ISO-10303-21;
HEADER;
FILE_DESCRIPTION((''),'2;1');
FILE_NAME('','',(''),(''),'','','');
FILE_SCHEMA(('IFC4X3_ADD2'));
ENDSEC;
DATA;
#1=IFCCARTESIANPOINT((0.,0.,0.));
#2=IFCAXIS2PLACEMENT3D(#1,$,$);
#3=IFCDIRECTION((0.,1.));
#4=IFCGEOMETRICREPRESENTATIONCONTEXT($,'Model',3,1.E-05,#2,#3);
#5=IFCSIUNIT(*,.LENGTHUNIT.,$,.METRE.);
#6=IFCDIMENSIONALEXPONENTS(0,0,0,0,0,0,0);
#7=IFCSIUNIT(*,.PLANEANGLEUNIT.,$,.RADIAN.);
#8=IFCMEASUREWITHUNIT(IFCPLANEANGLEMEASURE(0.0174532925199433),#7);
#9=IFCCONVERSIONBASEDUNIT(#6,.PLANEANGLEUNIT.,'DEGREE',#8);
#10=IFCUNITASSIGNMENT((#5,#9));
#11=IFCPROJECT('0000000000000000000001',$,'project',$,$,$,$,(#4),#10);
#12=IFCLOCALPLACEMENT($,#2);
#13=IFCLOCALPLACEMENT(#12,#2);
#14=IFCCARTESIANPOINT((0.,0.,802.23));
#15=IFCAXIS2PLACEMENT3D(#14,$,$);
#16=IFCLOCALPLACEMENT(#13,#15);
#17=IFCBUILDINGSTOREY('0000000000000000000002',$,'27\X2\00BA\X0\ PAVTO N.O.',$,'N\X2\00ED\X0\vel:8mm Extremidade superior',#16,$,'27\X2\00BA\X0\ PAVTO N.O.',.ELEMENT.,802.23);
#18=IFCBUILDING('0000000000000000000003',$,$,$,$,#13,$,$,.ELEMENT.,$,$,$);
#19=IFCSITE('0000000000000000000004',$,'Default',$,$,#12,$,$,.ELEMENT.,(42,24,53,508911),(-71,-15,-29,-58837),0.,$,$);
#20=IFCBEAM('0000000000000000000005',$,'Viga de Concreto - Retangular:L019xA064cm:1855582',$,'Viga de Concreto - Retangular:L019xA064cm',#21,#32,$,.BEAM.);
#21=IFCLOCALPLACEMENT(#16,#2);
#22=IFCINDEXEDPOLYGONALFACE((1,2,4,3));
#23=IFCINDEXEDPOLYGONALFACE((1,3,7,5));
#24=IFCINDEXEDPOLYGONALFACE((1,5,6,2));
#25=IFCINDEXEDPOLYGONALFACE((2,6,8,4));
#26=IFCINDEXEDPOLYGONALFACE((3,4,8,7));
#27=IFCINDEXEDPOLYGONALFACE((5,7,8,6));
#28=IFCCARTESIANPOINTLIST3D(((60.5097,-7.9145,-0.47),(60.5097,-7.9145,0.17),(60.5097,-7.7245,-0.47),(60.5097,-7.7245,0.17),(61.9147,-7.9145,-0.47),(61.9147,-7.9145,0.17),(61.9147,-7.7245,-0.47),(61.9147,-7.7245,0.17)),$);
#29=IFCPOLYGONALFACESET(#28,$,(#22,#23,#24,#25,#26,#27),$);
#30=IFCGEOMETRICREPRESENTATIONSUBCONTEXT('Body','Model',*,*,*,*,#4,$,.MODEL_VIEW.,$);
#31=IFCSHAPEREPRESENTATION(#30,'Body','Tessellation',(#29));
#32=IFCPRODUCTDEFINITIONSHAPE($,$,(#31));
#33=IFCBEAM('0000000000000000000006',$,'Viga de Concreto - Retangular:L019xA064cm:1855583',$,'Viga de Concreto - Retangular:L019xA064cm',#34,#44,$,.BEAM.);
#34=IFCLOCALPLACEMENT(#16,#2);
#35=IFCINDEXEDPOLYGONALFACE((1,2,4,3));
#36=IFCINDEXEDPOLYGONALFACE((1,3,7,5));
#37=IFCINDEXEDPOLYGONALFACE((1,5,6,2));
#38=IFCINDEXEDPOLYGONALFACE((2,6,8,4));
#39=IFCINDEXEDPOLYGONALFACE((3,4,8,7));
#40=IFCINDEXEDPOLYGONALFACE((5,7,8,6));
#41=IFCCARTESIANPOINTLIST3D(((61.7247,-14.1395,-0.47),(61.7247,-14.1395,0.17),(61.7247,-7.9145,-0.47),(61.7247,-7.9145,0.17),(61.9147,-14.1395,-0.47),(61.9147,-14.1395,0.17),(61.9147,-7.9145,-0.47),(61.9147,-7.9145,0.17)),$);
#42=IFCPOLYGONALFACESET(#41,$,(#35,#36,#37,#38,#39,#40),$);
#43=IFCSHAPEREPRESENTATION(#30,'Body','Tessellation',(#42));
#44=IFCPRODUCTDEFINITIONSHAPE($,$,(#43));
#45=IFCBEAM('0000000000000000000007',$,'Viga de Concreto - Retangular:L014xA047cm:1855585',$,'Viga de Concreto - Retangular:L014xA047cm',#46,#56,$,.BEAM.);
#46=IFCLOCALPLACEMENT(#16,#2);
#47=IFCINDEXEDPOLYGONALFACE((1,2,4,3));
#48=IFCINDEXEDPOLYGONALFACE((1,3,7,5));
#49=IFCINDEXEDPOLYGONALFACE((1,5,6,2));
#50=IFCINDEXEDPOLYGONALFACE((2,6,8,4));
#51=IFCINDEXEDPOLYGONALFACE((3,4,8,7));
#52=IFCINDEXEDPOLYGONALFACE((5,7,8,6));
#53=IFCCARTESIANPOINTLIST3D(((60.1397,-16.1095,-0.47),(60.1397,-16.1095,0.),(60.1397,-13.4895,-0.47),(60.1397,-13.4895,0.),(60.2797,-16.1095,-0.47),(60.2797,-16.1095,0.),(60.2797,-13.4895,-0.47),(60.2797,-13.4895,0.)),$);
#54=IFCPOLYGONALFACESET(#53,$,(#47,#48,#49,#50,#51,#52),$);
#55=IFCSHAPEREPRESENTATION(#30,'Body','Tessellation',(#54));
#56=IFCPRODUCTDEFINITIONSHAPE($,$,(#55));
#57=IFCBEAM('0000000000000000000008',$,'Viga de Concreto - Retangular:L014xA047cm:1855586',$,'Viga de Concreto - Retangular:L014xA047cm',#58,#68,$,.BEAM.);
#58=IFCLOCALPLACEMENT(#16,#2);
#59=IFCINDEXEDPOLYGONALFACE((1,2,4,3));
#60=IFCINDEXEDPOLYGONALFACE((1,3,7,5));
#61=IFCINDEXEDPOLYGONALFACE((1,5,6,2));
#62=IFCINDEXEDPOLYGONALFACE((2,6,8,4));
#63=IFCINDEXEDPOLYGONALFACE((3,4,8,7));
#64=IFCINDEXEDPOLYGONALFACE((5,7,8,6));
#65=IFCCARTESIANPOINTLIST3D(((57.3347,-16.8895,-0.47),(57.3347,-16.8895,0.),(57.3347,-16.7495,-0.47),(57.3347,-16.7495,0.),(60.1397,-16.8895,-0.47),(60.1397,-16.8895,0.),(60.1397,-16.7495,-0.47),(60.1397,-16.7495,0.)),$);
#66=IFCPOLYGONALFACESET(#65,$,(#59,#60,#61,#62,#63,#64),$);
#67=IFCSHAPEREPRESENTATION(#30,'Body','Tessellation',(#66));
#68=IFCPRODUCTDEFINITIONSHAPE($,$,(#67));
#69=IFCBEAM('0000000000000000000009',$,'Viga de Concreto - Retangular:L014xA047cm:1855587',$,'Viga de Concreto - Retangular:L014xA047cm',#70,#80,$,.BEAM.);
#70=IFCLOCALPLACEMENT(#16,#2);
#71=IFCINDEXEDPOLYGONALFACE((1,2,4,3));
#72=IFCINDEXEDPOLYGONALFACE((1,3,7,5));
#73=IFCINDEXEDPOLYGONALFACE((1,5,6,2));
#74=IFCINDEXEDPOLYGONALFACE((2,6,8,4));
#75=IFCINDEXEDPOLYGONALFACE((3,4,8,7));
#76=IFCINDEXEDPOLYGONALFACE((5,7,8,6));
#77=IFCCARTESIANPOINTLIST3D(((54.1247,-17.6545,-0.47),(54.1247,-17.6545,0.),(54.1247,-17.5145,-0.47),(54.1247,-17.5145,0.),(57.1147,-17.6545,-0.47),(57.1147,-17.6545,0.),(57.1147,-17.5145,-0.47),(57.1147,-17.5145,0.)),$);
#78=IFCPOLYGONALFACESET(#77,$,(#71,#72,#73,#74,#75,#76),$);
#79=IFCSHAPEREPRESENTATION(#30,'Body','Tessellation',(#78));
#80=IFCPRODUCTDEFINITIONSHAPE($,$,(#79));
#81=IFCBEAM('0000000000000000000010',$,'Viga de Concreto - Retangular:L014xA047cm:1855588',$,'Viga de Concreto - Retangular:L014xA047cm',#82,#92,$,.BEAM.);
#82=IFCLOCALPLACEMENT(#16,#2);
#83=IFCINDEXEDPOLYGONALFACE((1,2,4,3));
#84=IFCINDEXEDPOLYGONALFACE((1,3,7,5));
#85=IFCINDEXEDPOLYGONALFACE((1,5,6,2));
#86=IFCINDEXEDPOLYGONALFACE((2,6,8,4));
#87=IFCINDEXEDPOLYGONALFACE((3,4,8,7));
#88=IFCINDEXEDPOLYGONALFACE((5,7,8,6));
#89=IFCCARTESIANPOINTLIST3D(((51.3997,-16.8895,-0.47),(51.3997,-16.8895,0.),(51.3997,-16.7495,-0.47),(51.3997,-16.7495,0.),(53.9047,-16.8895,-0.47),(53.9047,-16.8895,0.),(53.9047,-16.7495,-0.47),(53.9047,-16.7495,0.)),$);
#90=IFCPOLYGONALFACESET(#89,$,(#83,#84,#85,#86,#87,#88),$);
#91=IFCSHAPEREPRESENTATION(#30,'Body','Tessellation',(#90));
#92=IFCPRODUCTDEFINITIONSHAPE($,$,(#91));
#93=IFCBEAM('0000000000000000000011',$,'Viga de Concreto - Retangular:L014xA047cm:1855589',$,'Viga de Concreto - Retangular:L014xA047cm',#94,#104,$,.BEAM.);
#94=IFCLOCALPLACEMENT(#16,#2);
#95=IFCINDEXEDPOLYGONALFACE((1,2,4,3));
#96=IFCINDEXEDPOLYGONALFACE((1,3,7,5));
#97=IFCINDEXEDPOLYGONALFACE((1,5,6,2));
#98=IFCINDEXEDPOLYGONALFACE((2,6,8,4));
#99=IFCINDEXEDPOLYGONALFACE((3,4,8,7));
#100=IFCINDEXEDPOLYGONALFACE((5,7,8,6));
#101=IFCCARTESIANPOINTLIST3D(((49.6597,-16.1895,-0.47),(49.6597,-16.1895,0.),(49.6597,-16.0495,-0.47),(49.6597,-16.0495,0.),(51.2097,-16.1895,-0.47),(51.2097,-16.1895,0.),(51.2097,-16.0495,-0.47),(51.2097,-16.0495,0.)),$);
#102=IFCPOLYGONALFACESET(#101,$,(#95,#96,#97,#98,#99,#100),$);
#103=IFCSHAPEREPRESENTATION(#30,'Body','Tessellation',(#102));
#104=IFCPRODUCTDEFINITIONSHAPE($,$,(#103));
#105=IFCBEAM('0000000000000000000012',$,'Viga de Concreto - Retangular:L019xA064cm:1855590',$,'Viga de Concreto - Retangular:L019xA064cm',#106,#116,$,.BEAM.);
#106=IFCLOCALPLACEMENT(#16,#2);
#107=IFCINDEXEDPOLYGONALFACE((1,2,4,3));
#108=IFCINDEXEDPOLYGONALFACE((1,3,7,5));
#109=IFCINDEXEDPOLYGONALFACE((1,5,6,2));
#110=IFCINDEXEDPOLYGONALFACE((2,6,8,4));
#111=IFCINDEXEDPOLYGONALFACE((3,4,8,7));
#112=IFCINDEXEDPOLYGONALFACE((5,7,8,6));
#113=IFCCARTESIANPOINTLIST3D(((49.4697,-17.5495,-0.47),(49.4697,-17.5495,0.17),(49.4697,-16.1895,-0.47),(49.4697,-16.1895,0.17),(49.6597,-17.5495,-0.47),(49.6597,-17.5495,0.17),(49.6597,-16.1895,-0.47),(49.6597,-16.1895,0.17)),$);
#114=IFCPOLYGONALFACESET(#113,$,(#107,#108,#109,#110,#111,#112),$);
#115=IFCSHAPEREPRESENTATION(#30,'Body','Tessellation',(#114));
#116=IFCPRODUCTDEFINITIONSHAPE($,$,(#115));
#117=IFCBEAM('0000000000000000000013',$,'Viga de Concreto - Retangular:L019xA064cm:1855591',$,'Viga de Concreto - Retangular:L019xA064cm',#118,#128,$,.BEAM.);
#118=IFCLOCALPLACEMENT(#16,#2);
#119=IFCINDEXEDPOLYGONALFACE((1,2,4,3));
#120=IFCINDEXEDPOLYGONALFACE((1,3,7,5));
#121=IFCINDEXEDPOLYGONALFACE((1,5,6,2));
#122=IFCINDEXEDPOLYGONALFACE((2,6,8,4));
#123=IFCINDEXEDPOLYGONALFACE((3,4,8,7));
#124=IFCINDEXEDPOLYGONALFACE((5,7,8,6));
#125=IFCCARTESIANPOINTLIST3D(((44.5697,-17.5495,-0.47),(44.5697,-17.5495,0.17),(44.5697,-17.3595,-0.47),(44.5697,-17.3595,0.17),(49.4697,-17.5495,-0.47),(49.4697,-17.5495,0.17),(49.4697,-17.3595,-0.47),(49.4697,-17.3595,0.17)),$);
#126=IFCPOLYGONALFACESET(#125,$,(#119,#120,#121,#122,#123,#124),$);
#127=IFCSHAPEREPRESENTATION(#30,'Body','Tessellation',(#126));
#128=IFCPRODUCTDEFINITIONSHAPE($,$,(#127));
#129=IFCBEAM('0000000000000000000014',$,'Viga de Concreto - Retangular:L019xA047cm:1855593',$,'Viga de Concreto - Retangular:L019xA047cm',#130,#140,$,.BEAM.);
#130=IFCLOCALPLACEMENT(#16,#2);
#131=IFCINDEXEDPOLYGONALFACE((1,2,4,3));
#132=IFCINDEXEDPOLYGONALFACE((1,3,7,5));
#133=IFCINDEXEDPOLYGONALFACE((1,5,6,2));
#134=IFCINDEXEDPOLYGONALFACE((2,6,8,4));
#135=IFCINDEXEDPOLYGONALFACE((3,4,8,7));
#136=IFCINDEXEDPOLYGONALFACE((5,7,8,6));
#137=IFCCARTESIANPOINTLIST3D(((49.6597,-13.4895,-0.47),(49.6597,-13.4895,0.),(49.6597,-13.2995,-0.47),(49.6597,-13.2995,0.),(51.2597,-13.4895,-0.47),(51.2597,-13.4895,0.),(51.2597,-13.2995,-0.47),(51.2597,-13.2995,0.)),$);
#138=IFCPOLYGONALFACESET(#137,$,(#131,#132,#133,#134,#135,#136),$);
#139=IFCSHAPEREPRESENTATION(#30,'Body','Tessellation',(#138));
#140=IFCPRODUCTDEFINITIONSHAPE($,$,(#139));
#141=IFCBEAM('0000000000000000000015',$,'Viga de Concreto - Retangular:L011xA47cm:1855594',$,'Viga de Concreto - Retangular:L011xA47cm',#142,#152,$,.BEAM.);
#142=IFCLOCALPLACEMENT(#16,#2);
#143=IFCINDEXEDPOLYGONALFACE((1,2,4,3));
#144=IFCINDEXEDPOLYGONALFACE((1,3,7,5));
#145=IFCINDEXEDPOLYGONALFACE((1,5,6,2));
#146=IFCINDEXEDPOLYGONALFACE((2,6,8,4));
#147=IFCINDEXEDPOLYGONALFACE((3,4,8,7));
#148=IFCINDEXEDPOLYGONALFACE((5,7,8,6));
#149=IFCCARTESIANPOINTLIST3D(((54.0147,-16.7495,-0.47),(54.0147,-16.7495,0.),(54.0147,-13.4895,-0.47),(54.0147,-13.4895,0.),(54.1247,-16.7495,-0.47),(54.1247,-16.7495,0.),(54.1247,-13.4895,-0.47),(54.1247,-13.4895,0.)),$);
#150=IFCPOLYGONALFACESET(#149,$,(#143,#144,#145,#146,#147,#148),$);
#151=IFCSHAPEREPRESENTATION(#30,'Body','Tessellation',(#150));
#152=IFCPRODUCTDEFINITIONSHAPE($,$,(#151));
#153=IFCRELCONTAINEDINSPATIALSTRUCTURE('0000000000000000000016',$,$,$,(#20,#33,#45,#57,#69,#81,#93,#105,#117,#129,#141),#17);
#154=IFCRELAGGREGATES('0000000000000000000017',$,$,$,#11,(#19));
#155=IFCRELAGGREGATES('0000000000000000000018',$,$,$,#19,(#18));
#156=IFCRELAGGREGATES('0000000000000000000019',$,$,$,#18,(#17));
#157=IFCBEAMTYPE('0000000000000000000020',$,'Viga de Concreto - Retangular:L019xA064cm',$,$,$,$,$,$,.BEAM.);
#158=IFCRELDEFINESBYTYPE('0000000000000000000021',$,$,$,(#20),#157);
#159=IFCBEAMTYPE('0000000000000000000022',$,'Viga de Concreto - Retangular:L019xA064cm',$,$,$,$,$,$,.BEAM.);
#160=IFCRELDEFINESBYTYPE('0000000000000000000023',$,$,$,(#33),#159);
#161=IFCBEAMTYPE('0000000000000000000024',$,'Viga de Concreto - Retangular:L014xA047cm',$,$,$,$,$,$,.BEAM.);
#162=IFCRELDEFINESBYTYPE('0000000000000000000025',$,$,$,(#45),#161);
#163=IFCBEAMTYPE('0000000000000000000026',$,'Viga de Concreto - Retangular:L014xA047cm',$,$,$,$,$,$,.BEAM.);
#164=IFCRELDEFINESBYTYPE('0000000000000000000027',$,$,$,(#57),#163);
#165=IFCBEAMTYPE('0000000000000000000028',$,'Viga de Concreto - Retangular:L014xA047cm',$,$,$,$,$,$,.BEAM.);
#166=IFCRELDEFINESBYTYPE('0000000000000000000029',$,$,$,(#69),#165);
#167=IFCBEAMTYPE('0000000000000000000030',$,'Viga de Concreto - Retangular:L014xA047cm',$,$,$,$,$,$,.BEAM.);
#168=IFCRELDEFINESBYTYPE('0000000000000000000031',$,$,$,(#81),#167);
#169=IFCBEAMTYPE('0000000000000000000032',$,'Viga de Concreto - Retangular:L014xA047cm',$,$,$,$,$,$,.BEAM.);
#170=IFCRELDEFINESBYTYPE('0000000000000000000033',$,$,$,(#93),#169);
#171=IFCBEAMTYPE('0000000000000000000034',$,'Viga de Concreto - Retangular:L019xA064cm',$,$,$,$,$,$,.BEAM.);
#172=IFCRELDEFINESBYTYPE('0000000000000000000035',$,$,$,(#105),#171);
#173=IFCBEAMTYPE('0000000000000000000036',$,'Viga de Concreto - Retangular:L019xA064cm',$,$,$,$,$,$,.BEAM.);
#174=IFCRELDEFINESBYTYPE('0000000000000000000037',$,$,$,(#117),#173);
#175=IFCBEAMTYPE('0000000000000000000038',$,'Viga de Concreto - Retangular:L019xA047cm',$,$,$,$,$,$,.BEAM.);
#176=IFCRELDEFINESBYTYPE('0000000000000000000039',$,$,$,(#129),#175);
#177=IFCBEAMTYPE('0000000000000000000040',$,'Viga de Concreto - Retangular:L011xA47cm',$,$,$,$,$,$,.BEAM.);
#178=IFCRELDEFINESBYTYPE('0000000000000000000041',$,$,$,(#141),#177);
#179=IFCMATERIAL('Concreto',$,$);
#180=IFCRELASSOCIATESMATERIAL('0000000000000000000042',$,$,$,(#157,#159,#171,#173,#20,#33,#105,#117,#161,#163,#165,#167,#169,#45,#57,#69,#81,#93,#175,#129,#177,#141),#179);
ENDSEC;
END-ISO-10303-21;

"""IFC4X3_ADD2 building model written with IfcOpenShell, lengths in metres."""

from ifc_helpers import new_model, entity, si_unit, converted_unit, direction, frame, frame_2d, origin, origin_2d_with_axis, place, context, subcontext, project, spatial, polyline, segment, composite_curve, rectangle, outline, extrude, source, transform, mapped, material, material_profile, profile_set, profile_usage, type_object, type_shapes, element, save


model = new_model("IFC4X3_ADD2")

# Units and contexts
model_context = context("Model", 3, precision=1e-05, world=origin(), true_north=direction((0.0, 1.0)))
body_context = subcontext(model_context, "Body", "Model", "MODEL_VIEW")
ifc_project = project(units=[si_unit("LENGTHUNIT", "METRE"), converted_unit("PLANEANGLEUNIT", "DEGREE", entity("IfcPlaneAngleMeasure", 0.0174532925199433), si_unit("PLANEANGLEUNIT", "RADIAN"), dimensions=[0, 0, 0, 0, 0, 0, 0])], contexts=[model_context])

# Site, building, storey
site_placement = place(None, origin())
site = spatial("IfcSite", under=ifc_project, at=site_placement, Name="Default", CompositionType="ELEMENT", RefLatitude=(42, 24, 53, 508911), RefLongitude=(-71, -15, -29, -58837), RefElevation=0.0)
building_placement = place(site_placement, origin())
building = spatial("IfcBuilding", under=site, at=building_placement, CompositionType="ELEMENT")
storey_placement = place(building_placement, frame((0.0, 0.0, 802.23)))
storey = spatial("IfcBuildingStorey", under=building, at=storey_placement, Name="27º PAVTO N.O.", ObjectType="Nível:8mm Extremidade superior", LongName="27º PAVTO N.O.", CompositionType="ELEMENT", Elevation=802.23)

# Beams
ifc_material = material(Name="Concreto")
ifc_material_profile_1 = material_profile(ifc_material, rectangle(XDim=0.64, YDim=0.19, at=frame_2d((0.0, 0.0), x_axis=(1.0, 0.0))), Name="L019xA064cm")
ifc_profile_set_1 = profile_set([ifc_material_profile_1], Name="L019xA064cm")
ifc_profile_usage_1 = profile_usage(ifc_profile_set_1, cardinal=8)
beam_type_1 = type_object("IfcBeamType", Name="Viga de Concreto - Retangular:L019xA064cm", PredefinedType="BEAM", material=ifc_profile_set_1)
shared_shape_1 = source(origin(), body_context, "Body", "SweptSolid", [
    extrude(rectangle(XDim=0.64, YDim=0.19, at=frame_2d((0.0, 0.0), x_axis=(1.0, 0.0))), frame((60.5097, -7.8195, 802.08), z_axis=(1.0, 0.0, 0.0), x_axis=(0.0, 0.0, -1.0)), (0.0, 0.0, 1.0), 1.405),
])
type_shapes(beam_type_1, [shared_shape_1])
beam_1_placement = place(storey_placement, frame((0.0, 0.0, -802.23)))
element("IfcBeam", 1, at=beam_1_placement, inside=storey, type_object=beam_type_1, material=ifc_profile_usage_1, Name="Viga de Concreto - Retangular:L019xA064cm:1855582", ObjectType="Viga de Concreto - Retangular:L019xA064cm", PredefinedType="BEAM", context=body_context, shape_type="MappedRepresentation", body=[
    mapped(shared_shape_1, transform((0.0, 0.0, 0.0), scale=1.0)),
])
beam_type_2 = type_object("IfcBeamType", Name="Viga de Concreto - Retangular:L019xA064cm", PredefinedType="BEAM", material=ifc_profile_set_1)
shared_shape_2 = source(origin(), body_context, "Body", "SweptSolid", [
    extrude(rectangle(XDim=0.64, YDim=0.19, at=frame_2d((0.0, 0.0), x_axis=(0.0, 1.0))), frame((61.8197, -7.9145, 802.08), z_axis=(0.0, -1.0, 0.0), x_axis=(-1.0, 0.0, 0.0)), (0.0, 0.0, 1.0), 6.225),
])
type_shapes(beam_type_2, [shared_shape_2])
beam_2_placement = place(storey_placement, frame((0.0, 0.0, -802.23)))
element("IfcBeam", 2, at=beam_2_placement, inside=storey, type_object=beam_type_2, material=ifc_profile_usage_1, Name="Viga de Concreto - Retangular:L019xA064cm:1855583", ObjectType="Viga de Concreto - Retangular:L019xA064cm", PredefinedType="BEAM", context=body_context, shape_type="MappedRepresentation", body=[
    mapped(shared_shape_2, transform((0.0, 0.0, 0.0), scale=1.0)),
])
ifc_material_profile_2 = material_profile(ifc_material, rectangle(XDim=0.47, YDim=0.14, at=frame_2d((0.0, 0.0), x_axis=(0.0, 1.0))), Name="L014xA047cm")
ifc_profile_set_2 = profile_set([ifc_material_profile_2], Name="L014xA047cm")
ifc_profile_usage_2 = profile_usage(ifc_profile_set_2, cardinal=8)
beam_type_3 = type_object("IfcBeamType", Name="Viga de Concreto - Retangular:L014xA047cm", PredefinedType="BEAM", material=ifc_profile_set_2)
shared_shape_3 = source(origin(), body_context, "Body", "SweptSolid", [
    extrude(rectangle(XDim=0.47, YDim=0.14, at=frame_2d((0.0, 0.0), x_axis=(0.0, 1.0))), frame((60.2097, -13.4895, 801.995), z_axis=(0.0, -1.0, 0.0), x_axis=(-1.0, 0.0, 0.0)), (0.0, 0.0, 1.0), 2.62),
])
type_shapes(beam_type_3, [shared_shape_3])
beam_3_placement = place(storey_placement, frame((0.0, 0.0, -802.23)))
element("IfcBeam", 3, at=beam_3_placement, inside=storey, type_object=beam_type_3, material=ifc_profile_usage_2, Name="Viga de Concreto - Retangular:L014xA047cm:1855585", ObjectType="Viga de Concreto - Retangular:L014xA047cm", PredefinedType="BEAM", context=body_context, shape_type="MappedRepresentation", body=[
    mapped(shared_shape_3, transform((0.0, 0.0, 0.0), scale=1.0)),
])
beam_type_4 = type_object("IfcBeamType", Name="Viga de Concreto - Retangular:L014xA047cm", PredefinedType="BEAM", material=ifc_profile_set_2)
shared_shape_4 = source(origin(), body_context, "Body", "SweptSolid", [
    extrude(rectangle(XDim=0.47, YDim=0.14, at=origin_2d_with_axis()), frame((60.1397, -16.8195, 801.995), z_axis=(-1.0, 0.0, 0.0), x_axis=(0.0, 0.0, -1.0)), (0.0, 0.0, 1.0), 2.805),
])
type_shapes(beam_type_4, [shared_shape_4])
beam_4_placement = place(storey_placement, frame((0.0, 0.0, -802.23)))
element("IfcBeam", 4, at=beam_4_placement, inside=storey, type_object=beam_type_4, material=ifc_profile_usage_2, Name="Viga de Concreto - Retangular:L014xA047cm:1855586", ObjectType="Viga de Concreto - Retangular:L014xA047cm", PredefinedType="BEAM", context=body_context, shape_type="MappedRepresentation", body=[
    mapped(shared_shape_4, transform((0.0, 0.0, 0.0), scale=1.0)),
])
beam_type_5 = type_object("IfcBeamType", Name="Viga de Concreto - Retangular:L014xA047cm", PredefinedType="BEAM", material=ifc_profile_set_2)
shared_shape_5 = source(origin(), body_context, "Body", "SweptSolid", [
    extrude(rectangle(XDim=0.47, YDim=0.14, at=origin_2d_with_axis()), frame((57.1147, -17.5845, 801.995), z_axis=(-1.0, 0.0, 0.0), x_axis=(0.0, 0.0, -1.0)), (0.0, 0.0, 1.0), 2.99),
])
type_shapes(beam_type_5, [shared_shape_5])
beam_5_placement = place(storey_placement, frame((0.0, 0.0, -802.23)))
element("IfcBeam", 5, at=beam_5_placement, inside=storey, type_object=beam_type_5, material=ifc_profile_usage_2, Name="Viga de Concreto - Retangular:L014xA047cm:1855587", ObjectType="Viga de Concreto - Retangular:L014xA047cm", PredefinedType="BEAM", context=body_context, shape_type="MappedRepresentation", body=[
    mapped(shared_shape_5, transform((0.0, 0.0, 0.0), scale=1.0)),
])
beam_type_6 = type_object("IfcBeamType", Name="Viga de Concreto - Retangular:L014xA047cm", PredefinedType="BEAM", material=ifc_profile_set_2)
shared_shape_6 = source(origin(), body_context, "Body", "SweptSolid", [
    extrude(rectangle(XDim=0.47, YDim=0.14, at=origin_2d_with_axis()), frame((53.9047, -16.8195, 801.995), z_axis=(-1.0, 0.0, 0.0), x_axis=(0.0, 0.0, -1.0)), (0.0, 0.0, 1.0), 2.505),
])
type_shapes(beam_type_6, [shared_shape_6])
beam_6_placement = place(storey_placement, frame((0.0, 0.0, -802.23)))
element("IfcBeam", 6, at=beam_6_placement, inside=storey, type_object=beam_type_6, material=ifc_profile_usage_2, Name="Viga de Concreto - Retangular:L014xA047cm:1855588", ObjectType="Viga de Concreto - Retangular:L014xA047cm", PredefinedType="BEAM", context=body_context, shape_type="MappedRepresentation", body=[
    mapped(shared_shape_6, transform((0.0, 0.0, 0.0), scale=1.0)),
])
beam_type_7 = type_object("IfcBeamType", Name="Viga de Concreto - Retangular:L014xA047cm", PredefinedType="BEAM", material=ifc_profile_set_2)
shared_shape_7 = source(origin(), body_context, "Body", "SweptSolid", [
    extrude(rectangle(XDim=0.47, YDim=0.14, at=origin_2d_with_axis()), frame((51.2097, -16.1195, 801.995), z_axis=(-1.0, 0.0, 0.0), x_axis=(0.0, 0.0, -1.0)), (0.0, 0.0, 1.0), 1.55),
])
type_shapes(beam_type_7, [shared_shape_7])
beam_7_placement = place(storey_placement, frame((0.0, 0.0, -802.23)))
element("IfcBeam", 7, at=beam_7_placement, inside=storey, type_object=beam_type_7, material=ifc_profile_usage_2, Name="Viga de Concreto - Retangular:L014xA047cm:1855589", ObjectType="Viga de Concreto - Retangular:L014xA047cm", PredefinedType="BEAM", context=body_context, shape_type="MappedRepresentation", body=[
    mapped(shared_shape_7, transform((0.0, 0.0, 0.0), scale=1.0)),
])
beam_type_8 = type_object("IfcBeamType", Name="Viga de Concreto - Retangular:L019xA064cm", PredefinedType="BEAM", material=ifc_profile_set_1)
shared_shape_8 = source(origin(), body_context, "Body", "SweptSolid", [
    extrude(rectangle(XDim=0.64, YDim=0.19, at=frame_2d((0.0, 0.0), x_axis=(0.0, 1.0))), frame((49.5647, -16.1895, 802.08), z_axis=(0.0, -1.0, 0.0), x_axis=(-1.0, 0.0, 0.0)), (0.0, 0.0, 1.0), 1.36),
])
type_shapes(beam_type_8, [shared_shape_8])
beam_8_placement = place(storey_placement, frame((0.0, 0.0, -802.23)))
element("IfcBeam", 8, at=beam_8_placement, inside=storey, type_object=beam_type_8, material=ifc_profile_usage_1, Name="Viga de Concreto - Retangular:L019xA064cm:1855590", ObjectType="Viga de Concreto - Retangular:L019xA064cm", PredefinedType="BEAM", context=body_context, shape_type="MappedRepresentation", body=[
    mapped(shared_shape_8, transform((0.0, 0.0, 0.0), scale=1.0)),
])
beam_type_9 = type_object("IfcBeamType", Name="Viga de Concreto - Retangular:L019xA064cm", PredefinedType="BEAM", material=ifc_profile_set_1)
shared_shape_9 = source(origin(), body_context, "Body", "SweptSolid", [
    extrude(rectangle(XDim=0.64, YDim=0.19, at=frame_2d((0.0, 0.0), x_axis=(1.0, 0.0))), frame((49.4697, -17.4545, 802.08), z_axis=(-1.0, 0.0, 0.0), x_axis=(0.0, 0.0, -1.0)), (0.0, 0.0, 1.0), 4.9),
])
type_shapes(beam_type_9, [shared_shape_9])
beam_9_placement = place(storey_placement, frame((0.0, 0.0, -802.23)))
element("IfcBeam", 9, at=beam_9_placement, inside=storey, type_object=beam_type_9, material=ifc_profile_usage_1, Name="Viga de Concreto - Retangular:L019xA064cm:1855591", ObjectType="Viga de Concreto - Retangular:L019xA064cm", PredefinedType="BEAM", context=body_context, shape_type="MappedRepresentation", body=[
    mapped(shared_shape_9, transform((0.0, 0.0, 0.0), scale=1.0)),
])
ifc_material_profile_3 = material_profile(ifc_material, rectangle(XDim=0.47, YDim=0.19, at=frame_2d((0.0, 0.0), x_axis=(0.0, 1.0))), Name="L019xA047cm")
ifc_profile_set_3 = profile_set([ifc_material_profile_3], Name="L019xA047cm")
ifc_profile_usage_3 = profile_usage(ifc_profile_set_3, cardinal=8)
beam_type_10 = type_object("IfcBeamType", Name="Viga de Concreto - Retangular:L019xA047cm", PredefinedType="BEAM", material=ifc_profile_set_3)
shared_shape_10 = source(origin(), body_context, "Body", "SweptSolid", [
    extrude(rectangle(XDim=0.47, YDim=0.19, at=frame_2d((0.0, 0.0), x_axis=(1.0, 0.0))), frame((51.2597, -13.3945, 801.995), z_axis=(-1.0, 0.0, 0.0), x_axis=(0.0, 0.0, -1.0)), (0.0, 0.0, 1.0), 1.6),
])
type_shapes(beam_type_10, [shared_shape_10])
beam_10_placement = place(storey_placement, frame((0.0, 0.0, -802.23)))
element("IfcBeam", 10, at=beam_10_placement, inside=storey, type_object=beam_type_10, material=ifc_profile_usage_3, Name="Viga de Concreto - Retangular:L019xA047cm:1855593", ObjectType="Viga de Concreto - Retangular:L019xA047cm", PredefinedType="BEAM", context=body_context, shape_type="MappedRepresentation", body=[
    mapped(shared_shape_10, transform((0.0, 0.0, 0.0), scale=1.0)),
])
ifc_material_profile_4 = material_profile(ifc_material, outline(composite_curve([segment(polyline([(-0.055, 0.235, 0.0), (0.055, 0.235, 0.0)]), True, "CONTINUOUS"), segment(polyline([(0.055, 0.235, 0.0), (0.055, -0.235, 0.0)]), True, "CONTINUOUS"), segment(polyline([(0.055, -0.235, 0.0), (-0.055, -0.235, 0.0)]), True, "CONTINUOUS"), segment(polyline([(-0.055, -0.235, 0.0), (-0.055, 0.235, 0.0)]), True, "CONTINUOUS")], self_intersect=False), kind="CURVE"), Name="L011xA47cm")
ifc_material_profile_5 = material_profile(ifc_material, outline(composite_curve([segment(polyline([(1.6775, -0.055, -0.235), (1.6775, -0.055, 0.235)]), True, "CONTINUOUS"), segment(polyline([(1.6775, -0.055, 0.235), (-1.6775, -0.055, 0.235)]), True, "CONTINUOUS"), segment(polyline([(-1.6775, -0.055, 0.235), (-1.6775, -0.055, -0.235)]), True, "CONTINUOUS"), segment(polyline([(-1.6775, -0.055, -0.235), (1.6775, -0.055, -0.235)]), True, "CONTINUOUS")], self_intersect=False), kind="CURVE"), Name="L011xA47cm")
ifc_profile_set_4 = profile_set([ifc_material_profile_4, ifc_material_profile_5], Name="L011xA47cm")
ifc_profile_usage_4 = profile_usage(ifc_profile_set_4, cardinal=8)
beam_type_11 = type_object("IfcBeamType", Name="Viga de Concreto - Retangular:L011xA47cm", PredefinedType="BEAM", material=ifc_profile_set_4)
shared_shape_11 = source(origin(), body_context, "Body", "SweptSolid", [
    extrude(rectangle(XDim=0.47, YDim=0.11, at=frame_2d((0.0, 0.0), x_axis=(0.0, 1.0))), frame((54.0697, -16.7495, 801.995), z_axis=(0.0, 1.0, 0.0), x_axis=(-1.0, 0.0, 0.0)), (0.0, 0.0, 1.0), 3.26),
])
type_shapes(beam_type_11, [shared_shape_11])
beam_11_placement = place(storey_placement, frame((0.0, 0.0, -802.23)))
element("IfcBeam", 11, at=beam_11_placement, inside=storey, type_object=beam_type_11, material=ifc_profile_usage_4, Name="Viga de Concreto - Retangular:L011xA47cm:1855594", ObjectType="Viga de Concreto - Retangular:L011xA47cm", PredefinedType="BEAM", context=body_context, shape_type="MappedRepresentation", body=[
    mapped(shared_shape_11, transform((0.0, 0.0, 0.0), scale=1.0)),
])

save(model, "model.ifc")
